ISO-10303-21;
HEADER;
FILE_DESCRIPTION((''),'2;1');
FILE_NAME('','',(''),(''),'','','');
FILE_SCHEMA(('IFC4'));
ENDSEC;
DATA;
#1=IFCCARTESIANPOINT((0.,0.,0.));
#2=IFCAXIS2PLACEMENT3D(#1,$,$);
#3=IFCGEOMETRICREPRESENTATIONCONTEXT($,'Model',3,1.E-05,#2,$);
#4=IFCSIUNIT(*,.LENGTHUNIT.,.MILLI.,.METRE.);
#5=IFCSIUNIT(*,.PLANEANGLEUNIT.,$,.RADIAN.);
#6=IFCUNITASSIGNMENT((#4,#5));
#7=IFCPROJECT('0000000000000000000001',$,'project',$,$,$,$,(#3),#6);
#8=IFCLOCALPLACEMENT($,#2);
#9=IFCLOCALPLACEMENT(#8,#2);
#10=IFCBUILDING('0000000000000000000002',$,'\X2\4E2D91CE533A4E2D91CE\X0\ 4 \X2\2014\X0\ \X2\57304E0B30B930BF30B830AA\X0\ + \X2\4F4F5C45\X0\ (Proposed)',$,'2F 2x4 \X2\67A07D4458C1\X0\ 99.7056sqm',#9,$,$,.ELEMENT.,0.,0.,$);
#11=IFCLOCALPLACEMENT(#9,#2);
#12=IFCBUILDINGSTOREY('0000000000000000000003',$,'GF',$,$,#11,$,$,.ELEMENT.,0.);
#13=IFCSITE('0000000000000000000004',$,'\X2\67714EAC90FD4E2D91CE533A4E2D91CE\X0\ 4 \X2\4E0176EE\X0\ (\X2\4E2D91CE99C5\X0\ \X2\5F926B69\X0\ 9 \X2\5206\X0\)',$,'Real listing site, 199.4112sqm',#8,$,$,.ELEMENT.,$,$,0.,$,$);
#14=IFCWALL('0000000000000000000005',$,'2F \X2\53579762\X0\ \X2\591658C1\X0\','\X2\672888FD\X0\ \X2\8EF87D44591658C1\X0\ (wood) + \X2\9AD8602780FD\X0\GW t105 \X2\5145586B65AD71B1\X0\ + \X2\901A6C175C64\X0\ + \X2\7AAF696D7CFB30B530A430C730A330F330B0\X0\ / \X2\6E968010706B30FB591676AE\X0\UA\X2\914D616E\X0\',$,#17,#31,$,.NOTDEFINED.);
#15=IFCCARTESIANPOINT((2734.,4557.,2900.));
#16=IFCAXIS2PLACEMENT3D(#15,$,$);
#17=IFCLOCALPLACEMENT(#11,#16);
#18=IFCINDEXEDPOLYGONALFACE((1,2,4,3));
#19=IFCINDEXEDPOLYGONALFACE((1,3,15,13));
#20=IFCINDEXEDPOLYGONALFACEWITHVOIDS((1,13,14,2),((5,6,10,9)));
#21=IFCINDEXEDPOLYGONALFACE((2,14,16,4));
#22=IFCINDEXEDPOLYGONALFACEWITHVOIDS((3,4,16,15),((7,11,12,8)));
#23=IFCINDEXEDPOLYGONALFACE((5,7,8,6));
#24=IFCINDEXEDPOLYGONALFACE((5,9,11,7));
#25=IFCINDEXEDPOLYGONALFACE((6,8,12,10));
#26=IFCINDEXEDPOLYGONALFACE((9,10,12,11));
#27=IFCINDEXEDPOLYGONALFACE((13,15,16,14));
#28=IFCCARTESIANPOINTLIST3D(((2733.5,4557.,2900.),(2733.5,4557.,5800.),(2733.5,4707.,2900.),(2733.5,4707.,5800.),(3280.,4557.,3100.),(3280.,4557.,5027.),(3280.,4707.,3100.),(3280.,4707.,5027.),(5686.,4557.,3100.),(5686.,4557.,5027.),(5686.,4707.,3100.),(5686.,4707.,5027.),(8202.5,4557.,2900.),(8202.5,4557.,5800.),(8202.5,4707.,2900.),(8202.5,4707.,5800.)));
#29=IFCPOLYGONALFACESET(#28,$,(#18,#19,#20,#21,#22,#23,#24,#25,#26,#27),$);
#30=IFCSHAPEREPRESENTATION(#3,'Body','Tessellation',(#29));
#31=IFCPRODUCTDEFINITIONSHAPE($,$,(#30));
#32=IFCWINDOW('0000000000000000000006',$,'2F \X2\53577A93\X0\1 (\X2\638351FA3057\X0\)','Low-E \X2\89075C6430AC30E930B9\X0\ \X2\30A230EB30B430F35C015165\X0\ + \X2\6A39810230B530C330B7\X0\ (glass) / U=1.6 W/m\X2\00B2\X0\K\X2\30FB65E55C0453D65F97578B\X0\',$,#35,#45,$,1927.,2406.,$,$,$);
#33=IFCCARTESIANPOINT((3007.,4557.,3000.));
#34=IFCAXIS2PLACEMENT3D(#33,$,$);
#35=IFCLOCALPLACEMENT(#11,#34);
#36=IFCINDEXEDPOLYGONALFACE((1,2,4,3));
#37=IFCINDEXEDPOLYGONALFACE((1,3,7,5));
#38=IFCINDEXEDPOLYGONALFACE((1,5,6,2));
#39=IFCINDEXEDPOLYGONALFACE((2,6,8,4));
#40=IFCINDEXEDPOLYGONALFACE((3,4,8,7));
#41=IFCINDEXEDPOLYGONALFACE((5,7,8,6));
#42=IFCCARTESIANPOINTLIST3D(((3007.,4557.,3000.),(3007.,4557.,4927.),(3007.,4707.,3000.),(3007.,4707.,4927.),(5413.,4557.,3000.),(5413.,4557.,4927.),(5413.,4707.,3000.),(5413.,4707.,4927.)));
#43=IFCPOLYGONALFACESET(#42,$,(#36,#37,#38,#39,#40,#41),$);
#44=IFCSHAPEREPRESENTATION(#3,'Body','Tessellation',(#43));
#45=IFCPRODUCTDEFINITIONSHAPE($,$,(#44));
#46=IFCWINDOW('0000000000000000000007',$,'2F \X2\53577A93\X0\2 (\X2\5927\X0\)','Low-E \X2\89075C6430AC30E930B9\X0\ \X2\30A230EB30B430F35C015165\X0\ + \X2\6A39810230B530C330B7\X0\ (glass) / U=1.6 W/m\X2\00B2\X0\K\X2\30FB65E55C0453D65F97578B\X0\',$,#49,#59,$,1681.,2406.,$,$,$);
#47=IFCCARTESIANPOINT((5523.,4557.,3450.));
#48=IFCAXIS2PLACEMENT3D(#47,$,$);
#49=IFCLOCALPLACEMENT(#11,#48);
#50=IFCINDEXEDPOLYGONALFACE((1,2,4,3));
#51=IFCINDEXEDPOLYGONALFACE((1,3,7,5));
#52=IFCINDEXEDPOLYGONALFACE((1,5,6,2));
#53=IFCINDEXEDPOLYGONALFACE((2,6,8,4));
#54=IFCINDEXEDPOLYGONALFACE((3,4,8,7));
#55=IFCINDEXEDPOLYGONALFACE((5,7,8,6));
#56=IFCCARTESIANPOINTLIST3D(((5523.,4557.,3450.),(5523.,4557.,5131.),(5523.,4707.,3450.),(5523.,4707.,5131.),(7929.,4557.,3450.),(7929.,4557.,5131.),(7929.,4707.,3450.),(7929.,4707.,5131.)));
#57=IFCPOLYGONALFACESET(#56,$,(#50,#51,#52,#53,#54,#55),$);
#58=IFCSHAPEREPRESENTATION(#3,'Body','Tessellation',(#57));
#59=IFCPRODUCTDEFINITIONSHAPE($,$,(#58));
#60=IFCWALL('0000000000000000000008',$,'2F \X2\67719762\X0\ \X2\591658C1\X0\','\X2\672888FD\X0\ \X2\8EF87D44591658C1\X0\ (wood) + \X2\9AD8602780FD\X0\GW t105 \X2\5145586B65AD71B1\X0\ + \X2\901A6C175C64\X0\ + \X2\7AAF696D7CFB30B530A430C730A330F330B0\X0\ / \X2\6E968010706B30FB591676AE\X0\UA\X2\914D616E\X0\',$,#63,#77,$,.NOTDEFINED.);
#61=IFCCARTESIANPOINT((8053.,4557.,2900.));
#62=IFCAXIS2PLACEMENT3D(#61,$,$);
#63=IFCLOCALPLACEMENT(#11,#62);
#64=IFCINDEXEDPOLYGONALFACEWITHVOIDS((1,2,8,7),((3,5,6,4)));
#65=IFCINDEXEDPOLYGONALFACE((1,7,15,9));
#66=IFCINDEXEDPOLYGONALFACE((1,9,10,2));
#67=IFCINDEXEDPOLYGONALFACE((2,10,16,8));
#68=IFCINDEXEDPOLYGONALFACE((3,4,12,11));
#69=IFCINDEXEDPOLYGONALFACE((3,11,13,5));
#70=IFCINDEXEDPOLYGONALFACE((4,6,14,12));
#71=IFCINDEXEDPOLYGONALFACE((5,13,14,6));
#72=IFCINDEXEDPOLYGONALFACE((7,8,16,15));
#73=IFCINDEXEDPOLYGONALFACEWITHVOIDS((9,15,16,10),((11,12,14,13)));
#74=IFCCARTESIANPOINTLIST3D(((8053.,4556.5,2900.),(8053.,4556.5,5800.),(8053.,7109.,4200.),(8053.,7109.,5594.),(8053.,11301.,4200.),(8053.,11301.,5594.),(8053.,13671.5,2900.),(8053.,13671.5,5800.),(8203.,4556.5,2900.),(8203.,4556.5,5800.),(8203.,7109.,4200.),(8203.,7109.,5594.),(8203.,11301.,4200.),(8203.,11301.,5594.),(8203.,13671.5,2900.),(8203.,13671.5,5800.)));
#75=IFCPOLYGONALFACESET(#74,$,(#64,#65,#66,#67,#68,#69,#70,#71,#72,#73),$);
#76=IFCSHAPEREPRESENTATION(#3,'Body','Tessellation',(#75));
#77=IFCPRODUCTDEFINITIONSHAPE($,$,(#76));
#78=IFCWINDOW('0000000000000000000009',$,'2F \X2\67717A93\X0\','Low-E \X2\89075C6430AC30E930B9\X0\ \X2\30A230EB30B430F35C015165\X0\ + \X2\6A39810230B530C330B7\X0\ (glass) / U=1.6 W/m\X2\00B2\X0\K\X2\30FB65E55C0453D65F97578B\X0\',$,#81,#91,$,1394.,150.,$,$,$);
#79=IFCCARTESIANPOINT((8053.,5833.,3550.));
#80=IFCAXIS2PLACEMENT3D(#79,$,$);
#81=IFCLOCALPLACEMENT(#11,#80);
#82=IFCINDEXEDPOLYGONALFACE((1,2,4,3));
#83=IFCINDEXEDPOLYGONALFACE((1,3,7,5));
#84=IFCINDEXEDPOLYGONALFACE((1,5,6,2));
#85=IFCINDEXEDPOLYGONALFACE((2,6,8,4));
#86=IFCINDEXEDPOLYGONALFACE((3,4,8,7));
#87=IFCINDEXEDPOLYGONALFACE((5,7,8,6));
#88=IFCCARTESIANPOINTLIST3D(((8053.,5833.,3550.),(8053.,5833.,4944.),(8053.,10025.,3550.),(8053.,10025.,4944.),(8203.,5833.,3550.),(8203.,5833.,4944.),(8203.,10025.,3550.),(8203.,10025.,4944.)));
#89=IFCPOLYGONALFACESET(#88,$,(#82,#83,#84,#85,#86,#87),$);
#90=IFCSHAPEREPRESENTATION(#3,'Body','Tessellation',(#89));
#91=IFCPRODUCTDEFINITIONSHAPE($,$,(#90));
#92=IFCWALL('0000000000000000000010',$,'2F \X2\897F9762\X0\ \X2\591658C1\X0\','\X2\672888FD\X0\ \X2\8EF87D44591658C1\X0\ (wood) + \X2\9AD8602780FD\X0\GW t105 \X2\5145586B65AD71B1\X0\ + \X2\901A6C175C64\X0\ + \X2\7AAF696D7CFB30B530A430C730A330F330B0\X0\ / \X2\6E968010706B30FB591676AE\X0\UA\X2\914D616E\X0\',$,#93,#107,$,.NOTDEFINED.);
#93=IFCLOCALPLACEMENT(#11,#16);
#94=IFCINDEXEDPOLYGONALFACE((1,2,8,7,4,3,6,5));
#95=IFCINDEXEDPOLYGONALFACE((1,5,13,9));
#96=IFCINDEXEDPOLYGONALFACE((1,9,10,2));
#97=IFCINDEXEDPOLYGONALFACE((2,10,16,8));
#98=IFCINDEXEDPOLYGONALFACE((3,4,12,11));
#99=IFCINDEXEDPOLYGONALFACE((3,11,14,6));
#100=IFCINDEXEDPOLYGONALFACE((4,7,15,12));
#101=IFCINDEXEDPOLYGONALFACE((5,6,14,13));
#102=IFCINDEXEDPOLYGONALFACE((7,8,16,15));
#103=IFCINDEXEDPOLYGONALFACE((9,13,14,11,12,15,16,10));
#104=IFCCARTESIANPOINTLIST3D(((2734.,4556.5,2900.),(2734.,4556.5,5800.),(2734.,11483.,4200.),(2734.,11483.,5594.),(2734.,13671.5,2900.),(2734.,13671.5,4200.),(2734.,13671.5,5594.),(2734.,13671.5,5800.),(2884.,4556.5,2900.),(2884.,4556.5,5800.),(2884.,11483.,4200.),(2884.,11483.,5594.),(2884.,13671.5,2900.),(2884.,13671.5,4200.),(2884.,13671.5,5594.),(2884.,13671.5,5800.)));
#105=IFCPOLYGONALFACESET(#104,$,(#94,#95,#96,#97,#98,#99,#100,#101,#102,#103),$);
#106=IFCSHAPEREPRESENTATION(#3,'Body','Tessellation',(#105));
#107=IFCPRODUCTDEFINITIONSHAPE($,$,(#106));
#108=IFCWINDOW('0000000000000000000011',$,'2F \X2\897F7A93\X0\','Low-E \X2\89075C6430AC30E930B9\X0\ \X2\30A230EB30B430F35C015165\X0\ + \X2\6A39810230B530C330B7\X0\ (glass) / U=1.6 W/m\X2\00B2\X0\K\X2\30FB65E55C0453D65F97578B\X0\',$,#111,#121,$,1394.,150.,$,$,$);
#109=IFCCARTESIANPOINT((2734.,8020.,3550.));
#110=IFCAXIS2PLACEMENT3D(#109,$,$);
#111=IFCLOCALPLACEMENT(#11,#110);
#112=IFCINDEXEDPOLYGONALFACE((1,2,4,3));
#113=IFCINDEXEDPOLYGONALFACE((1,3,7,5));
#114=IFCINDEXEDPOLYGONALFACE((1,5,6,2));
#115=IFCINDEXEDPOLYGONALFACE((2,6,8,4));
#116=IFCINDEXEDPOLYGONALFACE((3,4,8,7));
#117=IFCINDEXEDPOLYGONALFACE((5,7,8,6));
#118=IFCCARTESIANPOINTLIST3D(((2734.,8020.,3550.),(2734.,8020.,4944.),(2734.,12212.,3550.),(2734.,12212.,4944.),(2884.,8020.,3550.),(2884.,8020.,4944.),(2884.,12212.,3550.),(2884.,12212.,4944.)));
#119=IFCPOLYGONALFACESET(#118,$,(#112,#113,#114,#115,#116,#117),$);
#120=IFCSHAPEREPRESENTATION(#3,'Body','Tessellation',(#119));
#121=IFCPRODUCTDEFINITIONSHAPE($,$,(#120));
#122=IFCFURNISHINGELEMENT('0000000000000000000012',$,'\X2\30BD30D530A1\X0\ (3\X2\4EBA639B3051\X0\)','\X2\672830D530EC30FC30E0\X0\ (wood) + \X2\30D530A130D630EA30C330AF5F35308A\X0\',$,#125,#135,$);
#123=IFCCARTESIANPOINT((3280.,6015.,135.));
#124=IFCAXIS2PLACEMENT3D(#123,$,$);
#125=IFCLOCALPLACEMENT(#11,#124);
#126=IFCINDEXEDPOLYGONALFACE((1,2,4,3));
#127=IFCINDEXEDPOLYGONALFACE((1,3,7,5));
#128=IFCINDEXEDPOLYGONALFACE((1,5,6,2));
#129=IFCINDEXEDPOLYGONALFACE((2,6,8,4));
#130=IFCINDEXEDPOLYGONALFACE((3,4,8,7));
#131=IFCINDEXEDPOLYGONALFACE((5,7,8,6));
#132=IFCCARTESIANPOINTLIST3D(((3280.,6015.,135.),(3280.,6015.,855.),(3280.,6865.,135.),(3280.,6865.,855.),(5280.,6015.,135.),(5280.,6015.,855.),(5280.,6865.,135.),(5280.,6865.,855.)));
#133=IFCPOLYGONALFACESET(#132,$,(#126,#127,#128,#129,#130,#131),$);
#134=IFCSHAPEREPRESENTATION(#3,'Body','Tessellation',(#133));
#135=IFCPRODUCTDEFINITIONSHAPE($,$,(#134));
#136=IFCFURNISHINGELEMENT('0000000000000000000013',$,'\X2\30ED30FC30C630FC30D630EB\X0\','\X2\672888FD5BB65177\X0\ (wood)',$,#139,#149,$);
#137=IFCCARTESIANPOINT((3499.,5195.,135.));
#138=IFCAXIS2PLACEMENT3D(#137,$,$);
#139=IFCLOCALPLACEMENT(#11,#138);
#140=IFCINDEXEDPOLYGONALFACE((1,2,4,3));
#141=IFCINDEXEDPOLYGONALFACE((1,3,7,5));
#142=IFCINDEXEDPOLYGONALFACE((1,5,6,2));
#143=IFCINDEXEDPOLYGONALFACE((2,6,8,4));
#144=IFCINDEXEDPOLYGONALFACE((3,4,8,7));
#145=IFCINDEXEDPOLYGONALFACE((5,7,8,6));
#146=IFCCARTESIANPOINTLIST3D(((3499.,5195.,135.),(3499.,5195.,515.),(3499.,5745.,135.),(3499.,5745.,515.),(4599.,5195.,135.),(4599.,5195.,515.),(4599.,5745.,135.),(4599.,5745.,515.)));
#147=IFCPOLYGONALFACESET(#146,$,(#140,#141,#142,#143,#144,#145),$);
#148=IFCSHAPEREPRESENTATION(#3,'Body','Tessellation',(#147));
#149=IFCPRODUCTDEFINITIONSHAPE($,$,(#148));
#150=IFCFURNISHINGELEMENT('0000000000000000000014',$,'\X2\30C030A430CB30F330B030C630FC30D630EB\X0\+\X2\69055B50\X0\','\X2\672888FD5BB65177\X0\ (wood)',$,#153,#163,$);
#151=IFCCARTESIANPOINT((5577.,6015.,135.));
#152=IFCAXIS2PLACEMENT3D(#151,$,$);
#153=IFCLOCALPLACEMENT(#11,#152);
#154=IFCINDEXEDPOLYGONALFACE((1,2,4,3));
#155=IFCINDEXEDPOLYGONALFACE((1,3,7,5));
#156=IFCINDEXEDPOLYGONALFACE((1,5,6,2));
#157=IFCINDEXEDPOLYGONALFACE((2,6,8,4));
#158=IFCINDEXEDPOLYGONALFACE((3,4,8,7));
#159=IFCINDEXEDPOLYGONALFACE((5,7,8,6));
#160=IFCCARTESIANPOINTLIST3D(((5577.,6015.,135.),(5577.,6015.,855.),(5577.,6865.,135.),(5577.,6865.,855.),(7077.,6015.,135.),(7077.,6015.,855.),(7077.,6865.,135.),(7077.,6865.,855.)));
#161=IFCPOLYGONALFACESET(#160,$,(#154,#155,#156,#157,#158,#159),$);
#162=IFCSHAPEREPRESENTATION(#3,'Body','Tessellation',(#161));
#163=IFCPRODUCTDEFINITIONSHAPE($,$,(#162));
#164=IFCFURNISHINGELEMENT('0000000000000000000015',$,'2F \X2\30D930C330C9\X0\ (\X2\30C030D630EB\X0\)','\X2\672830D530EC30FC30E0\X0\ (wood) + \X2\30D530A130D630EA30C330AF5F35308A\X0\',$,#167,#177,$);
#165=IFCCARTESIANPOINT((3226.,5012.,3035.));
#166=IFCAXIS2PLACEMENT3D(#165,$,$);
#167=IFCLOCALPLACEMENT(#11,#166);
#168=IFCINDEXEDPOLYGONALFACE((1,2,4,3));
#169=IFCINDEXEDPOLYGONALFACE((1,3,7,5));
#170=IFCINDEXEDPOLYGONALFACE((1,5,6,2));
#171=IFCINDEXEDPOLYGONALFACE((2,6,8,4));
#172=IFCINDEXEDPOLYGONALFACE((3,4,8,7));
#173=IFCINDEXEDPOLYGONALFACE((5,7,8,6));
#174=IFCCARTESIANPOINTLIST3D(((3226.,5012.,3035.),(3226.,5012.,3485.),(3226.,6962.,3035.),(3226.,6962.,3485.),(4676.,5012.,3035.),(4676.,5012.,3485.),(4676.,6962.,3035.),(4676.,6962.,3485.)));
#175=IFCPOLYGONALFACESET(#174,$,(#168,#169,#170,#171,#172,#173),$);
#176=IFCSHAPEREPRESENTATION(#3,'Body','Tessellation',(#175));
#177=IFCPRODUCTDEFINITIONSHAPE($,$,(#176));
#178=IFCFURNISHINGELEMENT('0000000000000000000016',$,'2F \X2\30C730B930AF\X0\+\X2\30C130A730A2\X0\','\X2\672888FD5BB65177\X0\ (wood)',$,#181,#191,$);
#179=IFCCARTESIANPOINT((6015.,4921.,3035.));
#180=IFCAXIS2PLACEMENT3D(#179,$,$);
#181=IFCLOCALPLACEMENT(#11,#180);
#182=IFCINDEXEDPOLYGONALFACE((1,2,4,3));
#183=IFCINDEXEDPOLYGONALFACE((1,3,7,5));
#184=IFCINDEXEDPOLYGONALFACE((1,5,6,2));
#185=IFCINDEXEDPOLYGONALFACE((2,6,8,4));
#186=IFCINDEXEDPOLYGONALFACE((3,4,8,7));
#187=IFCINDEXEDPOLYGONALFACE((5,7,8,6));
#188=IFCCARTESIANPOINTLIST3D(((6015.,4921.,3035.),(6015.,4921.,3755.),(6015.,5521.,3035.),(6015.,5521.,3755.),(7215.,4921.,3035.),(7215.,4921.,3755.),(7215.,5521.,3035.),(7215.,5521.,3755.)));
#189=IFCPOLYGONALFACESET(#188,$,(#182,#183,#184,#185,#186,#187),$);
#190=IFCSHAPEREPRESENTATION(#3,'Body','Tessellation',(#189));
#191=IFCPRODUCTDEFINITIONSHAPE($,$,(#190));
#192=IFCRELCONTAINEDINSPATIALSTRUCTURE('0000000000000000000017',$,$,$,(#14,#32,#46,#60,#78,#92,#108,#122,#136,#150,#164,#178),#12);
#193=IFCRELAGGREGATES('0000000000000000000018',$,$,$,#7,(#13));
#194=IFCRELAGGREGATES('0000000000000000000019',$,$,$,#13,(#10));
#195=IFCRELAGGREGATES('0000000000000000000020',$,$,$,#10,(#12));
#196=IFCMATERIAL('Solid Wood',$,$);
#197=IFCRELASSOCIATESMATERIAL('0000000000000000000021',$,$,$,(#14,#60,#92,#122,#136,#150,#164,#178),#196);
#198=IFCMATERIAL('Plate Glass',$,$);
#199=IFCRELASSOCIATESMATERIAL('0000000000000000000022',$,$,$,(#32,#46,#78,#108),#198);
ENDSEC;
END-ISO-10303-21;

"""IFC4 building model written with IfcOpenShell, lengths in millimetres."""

from ifc_helpers import new_model, si_unit, frame, frame_2d, origin, place, context, project, spatial, rectangle, extrude, material, element, fill, save


model = new_model("IFC4")

# Units and contexts
model_context = context("Model", 3, precision=1e-05, world=origin())
ifc_project = project(units=[si_unit("LENGTHUNIT", "METRE", prefix="MILLI"), si_unit("PLANEANGLEUNIT", "RADIAN")], contexts=[model_context])

# Site, building, storey
site_placement = place(None, origin())
site = spatial("IfcSite", under=ifc_project, at=site_placement, Name="東京都中野区中野 4 丁目 (中野駅 徒歩 9 分)", ObjectType="Real listing site, 199.4112sqm", CompositionType="ELEMENT", RefElevation=0.0)
building_placement = place(site_placement, origin())
building = spatial("IfcBuilding", under=site, at=building_placement, Name="中野区中野 4 — 地下スタジオ + 住居 (Proposed)", ObjectType="2F 2x4 枠組壁 99.7056sqm", CompositionType="ELEMENT", ElevationOfRefHeight=0.0, ElevationOfTerrain=0.0)
storey_placement = place(building_placement, origin())
storey = spatial("IfcBuildingStorey", under=building, at=storey_placement, Name="GF", CompositionType="ELEMENT", Elevation=0.0)

# Shared definitions
ifc_material_1 = material(Name="Solid Wood")

# Wall, openings, windows
wall_1_placement = place(storey_placement, frame((2734.0, 4557.0, 2900.0)))
wall_1 = element("IfcWall", 1, at=wall_1_placement, inside=storey, material=ifc_material_1, Name="2F 南面 外壁", Description="木製 軸組外壁 (wood) + 高性能GW t105 充填断熱 + 通気層 + 窯業系サイディング / 準耐火・外皮UA配慮", PredefinedType="NOTDEFINED", context=model_context, shape_type="SweptSolid", body=[
    extrude(rectangle(XDim=5469.0, YDim=150.0, at=frame_2d((2734.0, 75.0))), frame((2734.0, 4557.0, 2900.0)), (0.0, 0.0, 1.0), 2900.0),
])
opening_1_placement = place(storey_placement, frame((3007.0, 4557.0, 3000.0)))
opening_1 = element("IfcOpeningElement", 2, at=opening_1_placement, cuts=wall_1, PredefinedType="NOTDEFINED", context=model_context, shape_type="SweptSolid", body=[
    extrude(rectangle(XDim=2406.0, YDim=150.0, at=frame_2d((1203.0, 75.0))), frame((3007.0, 4557.0, 3000.0)), (0.0, 0.0, 1.0), 1927.0),
])
opening_2_placement = place(storey_placement, frame((5523.0, 4557.0, 3450.0)))
opening_2 = element("IfcOpeningElement", 3, at=opening_2_placement, cuts=wall_1, PredefinedType="NOTDEFINED", context=model_context, shape_type="SweptSolid", body=[
    extrude(rectangle(XDim=2406.0, YDim=150.0, at=frame_2d((1203.0, 75.0))), frame((5523.0, 4557.0, 3450.0)), (0.0, 0.0, 1.0), 1681.0),
])
ifc_material_2 = material(Name="Plate Glass")
window_1_placement = place(storey_placement, frame((3007.0, 4557.0, 3000.0)))
window_1 = element("IfcWindow", 4, at=window_1_placement, inside=storey, material=ifc_material_2, Name="2F 南窓1 (掃出し)", Description="Low-E 複層ガラス アルゴン封入 + 樹脂サッシ (glass) / U=1.6 W/m²K・日射取得型", OverallHeight=1927.0, OverallWidth=2406.0, context=model_context, shape_type="SweptSolid", body=[
    extrude(rectangle(XDim=2406.0, YDim=150.0, at=frame_2d((1203.0, 75.0))), frame((3007.0, 4557.0, 3000.0)), (0.0, 0.0, 1.0), 1927.0),
])
fill(opening_1, window_1)
window_2_placement = place(storey_placement, frame((5523.0, 4557.0, 3450.0)))
window_2 = element("IfcWindow", 5, at=window_2_placement, inside=storey, material=ifc_material_2, Name="2F 南窓2 (大)", Description="Low-E 複層ガラス アルゴン封入 + 樹脂サッシ (glass) / U=1.6 W/m²K・日射取得型", OverallHeight=1681.0, OverallWidth=2406.0, context=model_context, shape_type="SweptSolid", body=[
    extrude(rectangle(XDim=2406.0, YDim=150.0, at=frame_2d((1203.0, 75.0))), frame((5523.0, 4557.0, 3450.0)), (0.0, 0.0, 1.0), 1681.0),
])
fill(opening_2, window_2)

# Walls, openings, windows
wall_2_placement = place(storey_placement, frame((8053.0, 4557.0, 2900.0)))
wall_2 = element("IfcWall", 6, at=wall_2_placement, inside=storey, material=ifc_material_1, Name="2F 東面 外壁", Description="木製 軸組外壁 (wood) + 高性能GW t105 充填断熱 + 通気層 + 窯業系サイディング / 準耐火・外皮UA配慮", PredefinedType="NOTDEFINED", context=model_context, shape_type="SweptSolid", body=[
    extrude(rectangle(XDim=150.0, YDim=9115.0, at=frame_2d((75.0, 4557.0))), frame((8053.0, 4557.0, 2900.0)), (0.0, 0.0, 1.0), 2900.0),
])
opening_3_placement = place(storey_placement, frame((8053.0, 5833.0, 3550.0)))
opening_3 = element("IfcOpeningElement", 7, at=opening_3_placement, cuts=wall_2, PredefinedType="NOTDEFINED", context=model_context, shape_type="SweptSolid", body=[
    extrude(rectangle(XDim=150.0, YDim=4192.0, at=frame_2d((75.0, 2096.0))), frame((8053.0, 5833.0, 3550.0)), (0.0, 0.0, 1.0), 1394.0),
])
window_3_placement = place(storey_placement, frame((8053.0, 5833.0, 3550.0)))
window_3 = element("IfcWindow", 8, at=window_3_placement, inside=storey, material=ifc_material_2, Name="2F 東窓", Description="Low-E 複層ガラス アルゴン封入 + 樹脂サッシ (glass) / U=1.6 W/m²K・日射取得型", OverallHeight=1394.0, OverallWidth=150.0, context=model_context, shape_type="SweptSolid", body=[
    extrude(rectangle(XDim=150.0, YDim=4192.0, at=frame_2d((75.0, 2096.0))), frame((8053.0, 5833.0, 3550.0)), (0.0, 0.0, 1.0), 1394.0),
])
fill(opening_3, window_3)
wall_3_placement = place(storey_placement, frame((2734.0, 4557.0, 2900.0)))
wall_3 = element("IfcWall", 9, at=wall_3_placement, inside=storey, material=ifc_material_1, Name="2F 西面 外壁", Description="木製 軸組外壁 (wood) + 高性能GW t105 充填断熱 + 通気層 + 窯業系サイディング / 準耐火・外皮UA配慮", PredefinedType="NOTDEFINED", context=model_context, shape_type="SweptSolid", body=[
    extrude(rectangle(XDim=150.0, YDim=9115.0, at=frame_2d((75.0, 4557.0))), frame((2734.0, 4557.0, 2900.0)), (0.0, 0.0, 1.0), 2900.0),
])
opening_4_placement = place(storey_placement, frame((2734.0, 8020.0, 3550.0)))
opening_4 = element("IfcOpeningElement", 10, at=opening_4_placement, cuts=wall_3, PredefinedType="NOTDEFINED", context=model_context, shape_type="SweptSolid", body=[
    extrude(rectangle(XDim=150.0, YDim=4192.0, at=frame_2d((75.0, 2096.0))), frame((2734.0, 8020.0, 3550.0)), (0.0, 0.0, 1.0), 1394.0),
])
window_4_placement = place(storey_placement, frame((2734.0, 8020.0, 3550.0)))
window_4 = element("IfcWindow", 11, at=window_4_placement, inside=storey, material=ifc_material_2, Name="2F 西窓", Description="Low-E 複層ガラス アルゴン封入 + 樹脂サッシ (glass) / U=1.6 W/m²K・日射取得型", OverallHeight=1394.0, OverallWidth=150.0, context=model_context, shape_type="SweptSolid", body=[
    extrude(rectangle(XDim=150.0, YDim=4192.0, at=frame_2d((75.0, 2096.0))), frame((2734.0, 8020.0, 3550.0)), (0.0, 0.0, 1.0), 1394.0),
])
fill(opening_4, window_4)

# Furnishing elements
furnishing_1_placement = place(storey_placement, frame((3280.0, 6015.0, 135.0)))
element("IfcFurnishingElement", 12, at=furnishing_1_placement, inside=storey, material=ifc_material_1, Name="ソファ (3人掛け)", Description="木フレーム (wood) + ファブリック張り", context=model_context, shape_type="SweptSolid", body=[
    extrude(rectangle(XDim=2000.0, YDim=850.0, at=frame_2d((1000.0, 425.0))), frame((3280.0, 6015.0, 135.0)), (0.0, 0.0, 1.0), 720.0),
])
furnishing_2_placement = place(storey_placement, frame((3499.0, 5195.0, 135.0)))
element("IfcFurnishingElement", 13, at=furnishing_2_placement, inside=storey, material=ifc_material_1, Name="ローテーブル", Description="木製家具 (wood)", context=model_context, shape_type="SweptSolid", body=[
    extrude(rectangle(XDim=1100.0, YDim=550.0, at=frame_2d((550.0, 275.0))), frame((3499.0, 5195.0, 135.0)), (0.0, 0.0, 1.0), 380.0),
])
furnishing_3_placement = place(storey_placement, frame((5577.0, 6015.0, 135.0)))
element("IfcFurnishingElement", 14, at=furnishing_3_placement, inside=storey, material=ifc_material_1, Name="ダイニングテーブル+椅子", Description="木製家具 (wood)", context=model_context, shape_type="SweptSolid", body=[
    extrude(rectangle(XDim=1500.0, YDim=850.0, at=frame_2d((750.0, 425.0))), frame((5577.0, 6015.0, 135.0)), (0.0, 0.0, 1.0), 720.0),
])
furnishing_4_placement = place(storey_placement, frame((3226.0, 5012.0, 3035.0)))
element("IfcFurnishingElement", 15, at=furnishing_4_placement, inside=storey, material=ifc_material_1, Name="2F ベッド (ダブル)", Description="木フレーム (wood) + ファブリック張り", context=model_context, shape_type="SweptSolid", body=[
    extrude(rectangle(XDim=1450.0, YDim=1950.0, at=frame_2d((725.0, 975.0))), frame((3226.0, 5012.0, 3035.0)), (0.0, 0.0, 1.0), 450.0),
])
furnishing_5_placement = place(storey_placement, frame((6015.0, 4921.0, 3035.0)))
element("IfcFurnishingElement", 16, at=furnishing_5_placement, inside=storey, material=ifc_material_1, Name="2F デスク+チェア", Description="木製家具 (wood)", context=model_context, shape_type="SweptSolid", body=[
    extrude(rectangle(XDim=1200.0, YDim=600.0, at=frame_2d((600.0, 300.0))), frame((6015.0, 4921.0, 3035.0)), (0.0, 0.0, 1.0), 720.0),
])

save(model, "model.ifc")
